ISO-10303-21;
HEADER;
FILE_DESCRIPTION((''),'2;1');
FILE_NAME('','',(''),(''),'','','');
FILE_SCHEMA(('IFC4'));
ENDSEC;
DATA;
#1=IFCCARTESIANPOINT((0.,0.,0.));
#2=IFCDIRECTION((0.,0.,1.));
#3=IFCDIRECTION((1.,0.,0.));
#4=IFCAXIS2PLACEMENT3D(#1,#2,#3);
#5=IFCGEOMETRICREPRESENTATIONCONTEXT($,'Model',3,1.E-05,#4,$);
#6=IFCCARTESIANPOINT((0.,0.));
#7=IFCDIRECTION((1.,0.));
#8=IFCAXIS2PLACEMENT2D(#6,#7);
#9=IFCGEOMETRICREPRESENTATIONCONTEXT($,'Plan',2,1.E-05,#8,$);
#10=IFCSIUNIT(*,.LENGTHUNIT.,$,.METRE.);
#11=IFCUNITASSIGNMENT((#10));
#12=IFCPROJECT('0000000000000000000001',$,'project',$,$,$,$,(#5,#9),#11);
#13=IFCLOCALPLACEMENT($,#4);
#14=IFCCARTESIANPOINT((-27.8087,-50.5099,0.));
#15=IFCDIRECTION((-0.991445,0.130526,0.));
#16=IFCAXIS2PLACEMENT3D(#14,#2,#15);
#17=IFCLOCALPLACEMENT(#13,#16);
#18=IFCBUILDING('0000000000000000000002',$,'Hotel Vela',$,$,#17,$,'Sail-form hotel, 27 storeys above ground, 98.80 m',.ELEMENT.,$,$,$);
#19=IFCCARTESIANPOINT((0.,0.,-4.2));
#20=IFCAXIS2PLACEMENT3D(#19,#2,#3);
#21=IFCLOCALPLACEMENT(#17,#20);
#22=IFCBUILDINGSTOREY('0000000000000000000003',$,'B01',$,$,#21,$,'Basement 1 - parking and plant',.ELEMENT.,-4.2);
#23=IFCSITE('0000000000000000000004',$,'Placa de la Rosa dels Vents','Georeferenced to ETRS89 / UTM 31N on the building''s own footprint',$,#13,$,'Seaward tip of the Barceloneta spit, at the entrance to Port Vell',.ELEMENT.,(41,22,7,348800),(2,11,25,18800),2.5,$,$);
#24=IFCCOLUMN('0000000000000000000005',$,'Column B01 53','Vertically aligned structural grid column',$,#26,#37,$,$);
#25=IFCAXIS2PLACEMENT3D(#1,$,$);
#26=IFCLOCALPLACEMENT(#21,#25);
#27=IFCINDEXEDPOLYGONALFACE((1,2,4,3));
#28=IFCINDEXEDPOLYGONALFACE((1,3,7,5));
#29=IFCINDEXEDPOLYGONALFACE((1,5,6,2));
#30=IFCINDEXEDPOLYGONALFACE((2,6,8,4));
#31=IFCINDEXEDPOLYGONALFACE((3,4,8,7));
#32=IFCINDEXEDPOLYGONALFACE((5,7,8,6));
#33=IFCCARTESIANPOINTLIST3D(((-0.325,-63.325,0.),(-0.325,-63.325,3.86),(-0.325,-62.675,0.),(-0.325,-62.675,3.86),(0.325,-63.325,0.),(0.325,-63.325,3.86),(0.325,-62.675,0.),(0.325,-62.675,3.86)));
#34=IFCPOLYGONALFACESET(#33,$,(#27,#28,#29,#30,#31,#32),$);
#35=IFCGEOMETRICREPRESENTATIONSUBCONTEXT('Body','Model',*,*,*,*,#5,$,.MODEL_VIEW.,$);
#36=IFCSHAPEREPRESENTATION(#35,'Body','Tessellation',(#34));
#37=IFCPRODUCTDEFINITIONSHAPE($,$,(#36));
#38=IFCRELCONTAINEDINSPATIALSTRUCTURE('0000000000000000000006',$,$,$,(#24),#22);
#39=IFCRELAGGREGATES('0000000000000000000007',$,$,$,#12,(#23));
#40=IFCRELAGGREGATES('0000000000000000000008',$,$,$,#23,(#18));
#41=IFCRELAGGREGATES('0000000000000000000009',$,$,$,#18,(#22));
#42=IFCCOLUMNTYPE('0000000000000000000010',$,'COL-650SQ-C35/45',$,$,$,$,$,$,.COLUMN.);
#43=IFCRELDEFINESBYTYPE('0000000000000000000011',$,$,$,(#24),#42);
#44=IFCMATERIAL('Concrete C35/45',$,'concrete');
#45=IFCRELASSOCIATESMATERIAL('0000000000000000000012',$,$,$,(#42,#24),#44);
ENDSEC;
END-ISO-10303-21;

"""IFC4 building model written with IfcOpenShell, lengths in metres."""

from ifc_helpers import new_model, si_unit, frame, origin_with_axes, origin_2d_with_axis, place, context, subcontext, project, spatial, line, indexed_curve, rectangle, outline, extrude, material, material_profile, profile_set, profile_usage, type_object, element, save


model = new_model("IFC4")

# Units and contexts
model_context = context("Model", 3, precision=1e-05, world=origin_with_axes())
plan_context = context("Plan", 2, precision=1e-05, world=origin_2d_with_axis())
body_context = subcontext(model_context, "Body", "Model", "MODEL_VIEW")
ifc_project = project(units=[si_unit("LENGTHUNIT", "METRE")], contexts=[model_context, plan_context])

# Site, building, storey
site_placement = place(None, origin_with_axes())
site = spatial("IfcSite", under=ifc_project, at=site_placement, Name="Placa de la Rosa dels Vents", Description="Georeferenced to ETRS89 / UTM 31N on the building's own footprint", LongName="Seaward tip of the Barceloneta spit, at the entrance to Port Vell", CompositionType="ELEMENT", RefLatitude=(41, 22, 7, 348800), RefLongitude=(2, 11, 25, 18800), RefElevation=2.5)
building_placement = place(site_placement, frame((-27.8087, -50.5099, 0.0), z_axis=(0.0, 0.0, 1.0), x_axis=(-0.991445, 0.130526, 0.0)))
building = spatial("IfcBuilding", under=site, at=building_placement, Name="Hotel Vela", LongName="Sail-form hotel, 27 storeys above ground, 98.80 m", CompositionType="ELEMENT")
storey_placement = place(building_placement, frame((0.0, 0.0, -4.2), z_axis=(0.0, 0.0, 1.0), x_axis=(1.0, 0.0, 0.0)))
storey = spatial("IfcBuildingStorey", under=building, at=storey_placement, Name="B01", LongName="Basement 1 - parking and plant", CompositionType="ELEMENT", Elevation=-4.2)

# Column
ifc_material = material(Name="Concrete C35/45", Category="concrete")
ifc_material_profile = material_profile(ifc_material, rectangle(XDim=0.65, YDim=0.65))
ifc_profile_set = profile_set([ifc_material_profile], Name="COL-650SQ-C35/45")
column_type = type_object("IfcColumnType", Name="COL-650SQ-C35/45", PredefinedType="COLUMN", material=ifc_profile_set)
ifc_profile_usage_1 = profile_usage(ifc_profile_set)
column_1_placement = place(storey_placement, frame((-0.325, -63.325, 0.0), z_axis=(0.0, 0.0, 1.0), x_axis=(1.0, 0.0, 0.0)))
element("IfcColumn", 1, at=column_1_placement, inside=storey, type_object=column_type, material=ifc_profile_usage_1, Name="Column B01 53", Description="Vertically aligned structural grid column", context=body_context, shape_type="SweptSolid", body=[
    extrude(outline(indexed_curve([(0.0, 0.0), (0.65, 0.0), (0.65, 0.65), (0.0, 0.65)], segments=[line(1, 2, 3, 4, 1)])), origin_with_axes(), (0.0, 0.0, 1.0), 3.86),
])

save(model, "model.ifc")
